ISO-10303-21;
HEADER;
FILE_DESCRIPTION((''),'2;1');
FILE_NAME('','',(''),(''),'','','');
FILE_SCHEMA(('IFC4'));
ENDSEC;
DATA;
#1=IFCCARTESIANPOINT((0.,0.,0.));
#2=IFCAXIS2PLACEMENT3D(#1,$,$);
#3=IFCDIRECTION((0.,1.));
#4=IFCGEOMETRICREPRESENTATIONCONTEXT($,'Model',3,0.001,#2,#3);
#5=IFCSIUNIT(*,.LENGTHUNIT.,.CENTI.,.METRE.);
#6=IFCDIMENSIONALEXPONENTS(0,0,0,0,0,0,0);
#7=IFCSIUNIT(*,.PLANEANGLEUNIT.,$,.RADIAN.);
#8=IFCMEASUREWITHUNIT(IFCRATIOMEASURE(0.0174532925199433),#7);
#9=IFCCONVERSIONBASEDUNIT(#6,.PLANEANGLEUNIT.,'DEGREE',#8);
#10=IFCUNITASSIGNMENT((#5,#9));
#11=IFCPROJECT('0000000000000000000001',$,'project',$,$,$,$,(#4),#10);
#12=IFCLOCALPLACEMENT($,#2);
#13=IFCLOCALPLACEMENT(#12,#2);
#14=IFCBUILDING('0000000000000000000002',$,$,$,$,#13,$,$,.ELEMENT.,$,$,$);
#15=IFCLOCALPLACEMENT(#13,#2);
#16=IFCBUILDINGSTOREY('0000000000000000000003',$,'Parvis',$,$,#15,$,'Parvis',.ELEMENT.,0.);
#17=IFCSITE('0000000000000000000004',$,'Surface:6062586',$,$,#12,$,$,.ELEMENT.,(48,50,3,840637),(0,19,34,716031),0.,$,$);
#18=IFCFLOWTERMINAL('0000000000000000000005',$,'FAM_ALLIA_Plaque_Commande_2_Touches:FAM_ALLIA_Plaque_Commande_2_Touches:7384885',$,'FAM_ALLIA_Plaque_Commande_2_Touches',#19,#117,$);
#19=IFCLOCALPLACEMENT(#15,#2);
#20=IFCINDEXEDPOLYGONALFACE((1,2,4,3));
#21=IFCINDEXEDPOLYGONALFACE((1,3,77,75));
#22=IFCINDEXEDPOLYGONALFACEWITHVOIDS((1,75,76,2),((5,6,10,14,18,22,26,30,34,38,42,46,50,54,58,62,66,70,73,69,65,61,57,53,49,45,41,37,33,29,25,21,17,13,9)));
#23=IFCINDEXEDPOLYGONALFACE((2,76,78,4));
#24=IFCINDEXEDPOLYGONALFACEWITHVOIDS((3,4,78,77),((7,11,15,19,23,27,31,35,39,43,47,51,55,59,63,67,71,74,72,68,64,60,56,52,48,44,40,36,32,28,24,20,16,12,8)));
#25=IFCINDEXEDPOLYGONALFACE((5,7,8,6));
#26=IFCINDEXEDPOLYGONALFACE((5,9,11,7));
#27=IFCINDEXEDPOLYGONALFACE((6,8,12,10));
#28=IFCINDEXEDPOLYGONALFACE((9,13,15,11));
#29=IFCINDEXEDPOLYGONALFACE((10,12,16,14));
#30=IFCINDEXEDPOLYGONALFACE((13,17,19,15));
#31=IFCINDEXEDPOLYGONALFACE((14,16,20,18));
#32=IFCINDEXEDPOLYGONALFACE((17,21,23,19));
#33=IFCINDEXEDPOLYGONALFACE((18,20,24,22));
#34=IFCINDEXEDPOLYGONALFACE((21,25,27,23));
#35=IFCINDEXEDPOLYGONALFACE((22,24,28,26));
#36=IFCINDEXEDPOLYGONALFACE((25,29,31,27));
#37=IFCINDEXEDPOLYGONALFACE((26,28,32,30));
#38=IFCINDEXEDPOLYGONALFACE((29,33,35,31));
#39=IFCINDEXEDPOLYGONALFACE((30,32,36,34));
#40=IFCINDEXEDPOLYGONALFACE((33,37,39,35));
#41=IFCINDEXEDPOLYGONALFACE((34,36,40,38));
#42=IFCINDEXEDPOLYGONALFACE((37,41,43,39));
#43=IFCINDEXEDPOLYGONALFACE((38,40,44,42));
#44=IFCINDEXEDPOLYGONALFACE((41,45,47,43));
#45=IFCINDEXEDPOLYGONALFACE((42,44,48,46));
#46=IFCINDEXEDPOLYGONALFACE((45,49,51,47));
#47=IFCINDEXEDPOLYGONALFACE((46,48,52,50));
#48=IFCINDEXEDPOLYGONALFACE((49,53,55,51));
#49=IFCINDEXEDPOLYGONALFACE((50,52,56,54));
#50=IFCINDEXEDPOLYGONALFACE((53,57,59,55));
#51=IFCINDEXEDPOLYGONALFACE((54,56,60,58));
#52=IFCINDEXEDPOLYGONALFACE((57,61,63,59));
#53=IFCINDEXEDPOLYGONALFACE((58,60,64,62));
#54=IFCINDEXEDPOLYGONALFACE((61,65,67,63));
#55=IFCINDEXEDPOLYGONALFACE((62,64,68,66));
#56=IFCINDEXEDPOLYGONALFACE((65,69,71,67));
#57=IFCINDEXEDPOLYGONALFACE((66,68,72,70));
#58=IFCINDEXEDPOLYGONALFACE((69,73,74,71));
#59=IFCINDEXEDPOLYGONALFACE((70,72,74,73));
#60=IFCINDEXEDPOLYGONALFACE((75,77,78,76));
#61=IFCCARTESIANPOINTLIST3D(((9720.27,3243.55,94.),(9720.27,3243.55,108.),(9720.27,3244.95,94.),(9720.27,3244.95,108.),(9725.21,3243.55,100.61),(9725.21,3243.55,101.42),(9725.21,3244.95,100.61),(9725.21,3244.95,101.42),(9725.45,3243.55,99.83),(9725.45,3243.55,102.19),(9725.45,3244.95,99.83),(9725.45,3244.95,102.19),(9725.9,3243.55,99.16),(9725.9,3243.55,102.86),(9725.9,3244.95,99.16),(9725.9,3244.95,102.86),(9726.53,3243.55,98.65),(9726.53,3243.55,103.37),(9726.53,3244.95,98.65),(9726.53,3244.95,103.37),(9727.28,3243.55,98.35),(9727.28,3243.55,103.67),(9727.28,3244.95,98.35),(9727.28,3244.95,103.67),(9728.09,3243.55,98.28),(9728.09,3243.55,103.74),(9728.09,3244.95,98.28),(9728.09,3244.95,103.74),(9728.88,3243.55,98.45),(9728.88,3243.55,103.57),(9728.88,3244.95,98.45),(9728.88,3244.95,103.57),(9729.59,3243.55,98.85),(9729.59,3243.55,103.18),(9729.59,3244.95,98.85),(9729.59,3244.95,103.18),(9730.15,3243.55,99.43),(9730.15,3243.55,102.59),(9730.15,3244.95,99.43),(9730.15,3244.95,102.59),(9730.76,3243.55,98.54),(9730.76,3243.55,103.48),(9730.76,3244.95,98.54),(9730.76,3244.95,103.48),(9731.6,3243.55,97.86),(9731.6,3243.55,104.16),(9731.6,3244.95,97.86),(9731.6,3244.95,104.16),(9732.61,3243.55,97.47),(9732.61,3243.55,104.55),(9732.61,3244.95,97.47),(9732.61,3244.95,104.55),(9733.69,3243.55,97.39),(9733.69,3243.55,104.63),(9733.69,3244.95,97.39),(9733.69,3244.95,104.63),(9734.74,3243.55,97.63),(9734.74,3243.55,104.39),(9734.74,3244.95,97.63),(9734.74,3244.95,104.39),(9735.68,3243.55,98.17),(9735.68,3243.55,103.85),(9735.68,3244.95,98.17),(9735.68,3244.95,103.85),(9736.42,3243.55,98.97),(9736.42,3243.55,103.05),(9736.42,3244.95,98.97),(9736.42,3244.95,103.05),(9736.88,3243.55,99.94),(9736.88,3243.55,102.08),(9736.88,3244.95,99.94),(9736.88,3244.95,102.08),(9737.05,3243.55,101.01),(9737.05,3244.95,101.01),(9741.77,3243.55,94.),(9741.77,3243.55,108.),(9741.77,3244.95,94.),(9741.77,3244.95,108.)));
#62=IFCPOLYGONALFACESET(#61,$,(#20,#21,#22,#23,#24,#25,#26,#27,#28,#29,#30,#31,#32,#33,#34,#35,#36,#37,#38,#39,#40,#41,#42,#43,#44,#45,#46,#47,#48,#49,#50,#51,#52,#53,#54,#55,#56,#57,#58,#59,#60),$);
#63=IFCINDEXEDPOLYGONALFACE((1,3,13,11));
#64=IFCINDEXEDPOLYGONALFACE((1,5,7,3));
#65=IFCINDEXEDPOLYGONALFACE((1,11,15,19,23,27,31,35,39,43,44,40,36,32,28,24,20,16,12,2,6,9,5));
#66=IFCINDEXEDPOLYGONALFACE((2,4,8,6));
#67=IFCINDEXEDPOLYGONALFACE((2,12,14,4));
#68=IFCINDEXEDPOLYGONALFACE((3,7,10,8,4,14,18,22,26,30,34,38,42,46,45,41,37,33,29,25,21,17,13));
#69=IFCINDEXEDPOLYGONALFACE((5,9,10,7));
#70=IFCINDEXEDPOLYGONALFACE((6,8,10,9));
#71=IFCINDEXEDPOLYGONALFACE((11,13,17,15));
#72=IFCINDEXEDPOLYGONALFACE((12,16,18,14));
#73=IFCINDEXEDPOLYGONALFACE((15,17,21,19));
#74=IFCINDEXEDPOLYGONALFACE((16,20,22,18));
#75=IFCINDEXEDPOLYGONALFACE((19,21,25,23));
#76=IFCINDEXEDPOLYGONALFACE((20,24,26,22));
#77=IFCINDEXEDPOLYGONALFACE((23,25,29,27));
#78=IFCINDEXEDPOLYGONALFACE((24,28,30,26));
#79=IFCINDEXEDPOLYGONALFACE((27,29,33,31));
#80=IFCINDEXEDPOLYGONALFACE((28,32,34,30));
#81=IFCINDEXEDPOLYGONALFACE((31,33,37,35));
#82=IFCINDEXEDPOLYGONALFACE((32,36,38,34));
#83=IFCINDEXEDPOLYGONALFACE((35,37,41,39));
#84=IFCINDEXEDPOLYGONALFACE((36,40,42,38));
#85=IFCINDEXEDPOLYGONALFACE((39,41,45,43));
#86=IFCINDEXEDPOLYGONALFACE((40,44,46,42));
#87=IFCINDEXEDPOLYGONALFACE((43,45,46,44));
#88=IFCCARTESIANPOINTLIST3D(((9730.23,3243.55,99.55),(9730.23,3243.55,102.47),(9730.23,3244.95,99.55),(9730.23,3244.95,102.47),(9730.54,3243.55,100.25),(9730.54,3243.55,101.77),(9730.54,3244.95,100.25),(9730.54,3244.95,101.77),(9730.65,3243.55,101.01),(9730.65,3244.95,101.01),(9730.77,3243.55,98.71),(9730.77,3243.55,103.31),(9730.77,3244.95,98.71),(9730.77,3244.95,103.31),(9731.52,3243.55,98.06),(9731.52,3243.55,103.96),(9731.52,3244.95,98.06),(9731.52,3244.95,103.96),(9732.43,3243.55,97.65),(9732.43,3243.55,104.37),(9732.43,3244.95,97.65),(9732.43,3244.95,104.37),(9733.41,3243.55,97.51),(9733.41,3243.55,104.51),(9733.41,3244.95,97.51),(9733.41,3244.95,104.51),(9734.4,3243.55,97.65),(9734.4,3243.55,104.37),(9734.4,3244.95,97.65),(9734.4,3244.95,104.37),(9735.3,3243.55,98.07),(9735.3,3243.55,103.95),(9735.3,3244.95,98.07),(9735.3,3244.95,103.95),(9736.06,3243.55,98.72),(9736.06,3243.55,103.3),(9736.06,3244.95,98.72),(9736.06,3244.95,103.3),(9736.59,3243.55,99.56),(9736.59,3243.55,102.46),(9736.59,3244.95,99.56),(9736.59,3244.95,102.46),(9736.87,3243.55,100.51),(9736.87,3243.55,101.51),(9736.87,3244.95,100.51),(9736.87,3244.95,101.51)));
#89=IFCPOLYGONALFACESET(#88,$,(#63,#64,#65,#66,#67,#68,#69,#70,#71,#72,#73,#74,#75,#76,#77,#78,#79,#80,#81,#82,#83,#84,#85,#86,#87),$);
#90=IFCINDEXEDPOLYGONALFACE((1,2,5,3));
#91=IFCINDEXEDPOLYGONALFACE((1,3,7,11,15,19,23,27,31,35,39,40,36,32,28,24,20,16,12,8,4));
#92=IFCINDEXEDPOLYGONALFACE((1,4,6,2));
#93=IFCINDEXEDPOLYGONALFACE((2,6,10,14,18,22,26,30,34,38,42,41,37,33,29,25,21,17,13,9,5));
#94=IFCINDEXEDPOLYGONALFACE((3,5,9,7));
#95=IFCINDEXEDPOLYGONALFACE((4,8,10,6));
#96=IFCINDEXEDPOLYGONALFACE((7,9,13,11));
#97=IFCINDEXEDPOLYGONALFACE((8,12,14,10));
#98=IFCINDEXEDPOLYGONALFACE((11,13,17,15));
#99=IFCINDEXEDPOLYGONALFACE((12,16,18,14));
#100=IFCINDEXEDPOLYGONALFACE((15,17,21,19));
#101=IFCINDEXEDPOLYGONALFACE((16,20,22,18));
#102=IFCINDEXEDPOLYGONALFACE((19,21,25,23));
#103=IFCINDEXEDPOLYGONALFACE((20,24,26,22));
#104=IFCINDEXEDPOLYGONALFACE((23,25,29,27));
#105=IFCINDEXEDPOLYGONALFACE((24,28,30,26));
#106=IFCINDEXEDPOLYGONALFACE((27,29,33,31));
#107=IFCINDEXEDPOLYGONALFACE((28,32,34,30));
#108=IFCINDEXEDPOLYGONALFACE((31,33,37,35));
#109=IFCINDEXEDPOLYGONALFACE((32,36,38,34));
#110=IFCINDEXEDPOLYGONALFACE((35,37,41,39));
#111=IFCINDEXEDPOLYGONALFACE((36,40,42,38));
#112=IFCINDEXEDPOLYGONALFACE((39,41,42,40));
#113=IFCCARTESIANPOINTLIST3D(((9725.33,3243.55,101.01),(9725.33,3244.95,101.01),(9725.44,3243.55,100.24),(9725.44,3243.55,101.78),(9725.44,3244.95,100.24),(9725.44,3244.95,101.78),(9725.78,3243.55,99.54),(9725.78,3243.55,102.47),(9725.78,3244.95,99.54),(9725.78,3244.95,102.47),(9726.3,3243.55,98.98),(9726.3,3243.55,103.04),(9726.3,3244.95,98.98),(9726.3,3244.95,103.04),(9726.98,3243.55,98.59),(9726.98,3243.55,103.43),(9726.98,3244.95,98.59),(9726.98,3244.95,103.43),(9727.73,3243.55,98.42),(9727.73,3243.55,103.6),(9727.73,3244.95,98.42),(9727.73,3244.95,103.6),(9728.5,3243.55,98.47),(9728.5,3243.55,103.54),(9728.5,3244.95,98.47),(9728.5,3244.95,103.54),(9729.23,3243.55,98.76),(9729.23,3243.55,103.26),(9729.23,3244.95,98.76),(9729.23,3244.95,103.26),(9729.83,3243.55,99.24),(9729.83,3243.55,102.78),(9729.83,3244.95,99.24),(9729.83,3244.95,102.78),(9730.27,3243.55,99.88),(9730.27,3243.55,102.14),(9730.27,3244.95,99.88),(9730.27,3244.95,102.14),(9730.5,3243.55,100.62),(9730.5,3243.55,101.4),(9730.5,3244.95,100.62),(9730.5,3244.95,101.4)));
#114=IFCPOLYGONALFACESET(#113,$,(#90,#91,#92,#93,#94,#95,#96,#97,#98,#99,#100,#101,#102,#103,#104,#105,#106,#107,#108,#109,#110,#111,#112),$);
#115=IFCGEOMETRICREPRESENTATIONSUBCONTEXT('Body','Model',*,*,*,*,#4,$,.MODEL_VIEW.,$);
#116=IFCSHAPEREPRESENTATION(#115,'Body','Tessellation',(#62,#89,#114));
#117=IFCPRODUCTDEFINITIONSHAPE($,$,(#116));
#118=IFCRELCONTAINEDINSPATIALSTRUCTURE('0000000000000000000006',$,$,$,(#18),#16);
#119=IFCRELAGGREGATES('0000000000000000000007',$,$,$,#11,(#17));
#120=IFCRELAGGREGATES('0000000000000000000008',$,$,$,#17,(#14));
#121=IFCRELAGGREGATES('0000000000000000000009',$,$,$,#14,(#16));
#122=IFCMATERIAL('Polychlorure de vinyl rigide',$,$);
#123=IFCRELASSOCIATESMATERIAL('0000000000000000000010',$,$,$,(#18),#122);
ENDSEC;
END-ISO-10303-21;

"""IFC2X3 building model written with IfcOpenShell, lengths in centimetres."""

from ifc_helpers import new_model, entity, si_unit, converted_unit, direction, frame, frame_2d, origin, place, context, subcontext, project, spatial, polyline, circle_curve, parameter, trimmed, segment, composite_curve, circle, outline, extrude, source, transform, mapped, material, element, save


model = new_model("IFC2X3")

# Units and contexts
model_context = context("Model", 3, precision=0.001, world=origin(), true_north=direction((0.0, 1.0)))
body_context = subcontext(model_context, "Body", "Model", "MODEL_VIEW")
ifc_project = project(units=[si_unit("LENGTHUNIT", "METRE", prefix="CENTI"), converted_unit("PLANEANGLEUNIT", "DEGREE", entity("IfcRatioMeasure", 0.0174532925199433), si_unit("PLANEANGLEUNIT", "RADIAN"), dimensions=[0, 0, 0, 0, 0, 0, 0])], contexts=[model_context])

# Site, building, storey
site_placement = place(None, origin())
site = spatial("IfcSite", under=ifc_project, at=site_placement, Name="Surface:6062586", CompositionType="ELEMENT", RefLatitude=(48, 50, 3, 840637), RefLongitude=(0, 19, 34, 716031), RefElevation=0.0)
building_placement = place(site_placement, origin())
building = spatial("IfcBuilding", under=site, at=building_placement, CompositionType="ELEMENT")
storey_placement = place(building_placement, frame((0.0, 0.0, 0.0)))
storey = spatial("IfcBuildingStorey", under=building, at=storey_placement, Name="Parvis", LongName="Parvis", CompositionType="ELEMENT", Elevation=0.0)

# Flow terminal
ifc_material_1 = material(Name="Polychlorure de vinyl rigide")
shared_shape_1 = source(origin(), body_context, "Body", "SweptSolid", [
    extrude(outline(polyline([(-10.75, -7.0), (10.75, -7.0), (10.75, 7.0), (-10.75, 7.0), (-10.75, -7.0)]), holes=[composite_curve([segment(trimmed(circle_curve(frame_2d((2.39, 0.01), x_axis=(-1.0, 0.0)), 3.63), [parameter(25.817037)], [parameter(334.182963)], True, "PARAMETER"), False, "CONTINUOUS"), segment(trimmed(circle_curve(frame_2d((-3.1, 0.01), x_axis=(-1.0, 0.0)), 2.73), [parameter(215.328783)], [parameter(144.671217)], True, "PARAMETER"), False, "CONTINUOUS")], self_intersect=False)]), frame((10.75, 0.0, 7.0), z_axis=(0.0, 1.0, 0.0), x_axis=(-1.0, 0.0, 0.0)), (0.0, 0.0, 1.0), 1.4),
    extrude(outline(composite_curve([segment(trimmed(circle_curve(frame_2d((-3.18, 0.0), x_axis=(1.0, 0.0)), 3.5), [parameter(24.658608)], [parameter(335.369251)], True, "PARAMETER"), True, "CONTINUOUS"), segment(trimmed(circle_curve(frame_2d((2.31, 0.0), x_axis=(1.0, 0.0)), 2.73), [parameter(147.747195)], [parameter(212.280664)], True, "PARAMETER"), False, "CONTINUOUS")], self_intersect=False)), frame((11.54, 0.0, 7.01), z_axis=(0.0, -1.0, 0.0), x_axis=(1.0, 0.0, 0.0)), (0.0, 0.0, -1.0), 1.4),
    extrude(circle(Radius=2.6, at=frame_2d((0.0, 0.0), x_axis=(1.0, 0.0))), frame((13.85, 0.0, 7.01), z_axis=(0.0, 1.0, 0.0), x_axis=(1.0, 0.0, 0.0)), (0.0, 0.0, 1.0), 1.4),
])
for number, where, z_axis, x_axis, name in (
    (1, (9741.77, 3244.95, 94.0), (0.0, 0.0, 1.0), (-1.0, 0.0, 0.0), "FAM_ALLIA_Plaque_Commande_2_Touches:FAM_ALLIA_Plaque_Commande_2_Touches:7384885"),
):
    element("IfcFlowTerminal", number, at=place(storey_placement, frame(where, z_axis=z_axis, x_axis=x_axis)), inside=storey, material=ifc_material_1, Name=name, ObjectType="FAM_ALLIA_Plaque_Commande_2_Touches", context=body_context, shape_type="MappedRepresentation", body=[
        mapped(shared_shape_1, transform((0.0, 0.0, 0.0), scale=1.0)),
    ])

save(model, "model.ifc")
